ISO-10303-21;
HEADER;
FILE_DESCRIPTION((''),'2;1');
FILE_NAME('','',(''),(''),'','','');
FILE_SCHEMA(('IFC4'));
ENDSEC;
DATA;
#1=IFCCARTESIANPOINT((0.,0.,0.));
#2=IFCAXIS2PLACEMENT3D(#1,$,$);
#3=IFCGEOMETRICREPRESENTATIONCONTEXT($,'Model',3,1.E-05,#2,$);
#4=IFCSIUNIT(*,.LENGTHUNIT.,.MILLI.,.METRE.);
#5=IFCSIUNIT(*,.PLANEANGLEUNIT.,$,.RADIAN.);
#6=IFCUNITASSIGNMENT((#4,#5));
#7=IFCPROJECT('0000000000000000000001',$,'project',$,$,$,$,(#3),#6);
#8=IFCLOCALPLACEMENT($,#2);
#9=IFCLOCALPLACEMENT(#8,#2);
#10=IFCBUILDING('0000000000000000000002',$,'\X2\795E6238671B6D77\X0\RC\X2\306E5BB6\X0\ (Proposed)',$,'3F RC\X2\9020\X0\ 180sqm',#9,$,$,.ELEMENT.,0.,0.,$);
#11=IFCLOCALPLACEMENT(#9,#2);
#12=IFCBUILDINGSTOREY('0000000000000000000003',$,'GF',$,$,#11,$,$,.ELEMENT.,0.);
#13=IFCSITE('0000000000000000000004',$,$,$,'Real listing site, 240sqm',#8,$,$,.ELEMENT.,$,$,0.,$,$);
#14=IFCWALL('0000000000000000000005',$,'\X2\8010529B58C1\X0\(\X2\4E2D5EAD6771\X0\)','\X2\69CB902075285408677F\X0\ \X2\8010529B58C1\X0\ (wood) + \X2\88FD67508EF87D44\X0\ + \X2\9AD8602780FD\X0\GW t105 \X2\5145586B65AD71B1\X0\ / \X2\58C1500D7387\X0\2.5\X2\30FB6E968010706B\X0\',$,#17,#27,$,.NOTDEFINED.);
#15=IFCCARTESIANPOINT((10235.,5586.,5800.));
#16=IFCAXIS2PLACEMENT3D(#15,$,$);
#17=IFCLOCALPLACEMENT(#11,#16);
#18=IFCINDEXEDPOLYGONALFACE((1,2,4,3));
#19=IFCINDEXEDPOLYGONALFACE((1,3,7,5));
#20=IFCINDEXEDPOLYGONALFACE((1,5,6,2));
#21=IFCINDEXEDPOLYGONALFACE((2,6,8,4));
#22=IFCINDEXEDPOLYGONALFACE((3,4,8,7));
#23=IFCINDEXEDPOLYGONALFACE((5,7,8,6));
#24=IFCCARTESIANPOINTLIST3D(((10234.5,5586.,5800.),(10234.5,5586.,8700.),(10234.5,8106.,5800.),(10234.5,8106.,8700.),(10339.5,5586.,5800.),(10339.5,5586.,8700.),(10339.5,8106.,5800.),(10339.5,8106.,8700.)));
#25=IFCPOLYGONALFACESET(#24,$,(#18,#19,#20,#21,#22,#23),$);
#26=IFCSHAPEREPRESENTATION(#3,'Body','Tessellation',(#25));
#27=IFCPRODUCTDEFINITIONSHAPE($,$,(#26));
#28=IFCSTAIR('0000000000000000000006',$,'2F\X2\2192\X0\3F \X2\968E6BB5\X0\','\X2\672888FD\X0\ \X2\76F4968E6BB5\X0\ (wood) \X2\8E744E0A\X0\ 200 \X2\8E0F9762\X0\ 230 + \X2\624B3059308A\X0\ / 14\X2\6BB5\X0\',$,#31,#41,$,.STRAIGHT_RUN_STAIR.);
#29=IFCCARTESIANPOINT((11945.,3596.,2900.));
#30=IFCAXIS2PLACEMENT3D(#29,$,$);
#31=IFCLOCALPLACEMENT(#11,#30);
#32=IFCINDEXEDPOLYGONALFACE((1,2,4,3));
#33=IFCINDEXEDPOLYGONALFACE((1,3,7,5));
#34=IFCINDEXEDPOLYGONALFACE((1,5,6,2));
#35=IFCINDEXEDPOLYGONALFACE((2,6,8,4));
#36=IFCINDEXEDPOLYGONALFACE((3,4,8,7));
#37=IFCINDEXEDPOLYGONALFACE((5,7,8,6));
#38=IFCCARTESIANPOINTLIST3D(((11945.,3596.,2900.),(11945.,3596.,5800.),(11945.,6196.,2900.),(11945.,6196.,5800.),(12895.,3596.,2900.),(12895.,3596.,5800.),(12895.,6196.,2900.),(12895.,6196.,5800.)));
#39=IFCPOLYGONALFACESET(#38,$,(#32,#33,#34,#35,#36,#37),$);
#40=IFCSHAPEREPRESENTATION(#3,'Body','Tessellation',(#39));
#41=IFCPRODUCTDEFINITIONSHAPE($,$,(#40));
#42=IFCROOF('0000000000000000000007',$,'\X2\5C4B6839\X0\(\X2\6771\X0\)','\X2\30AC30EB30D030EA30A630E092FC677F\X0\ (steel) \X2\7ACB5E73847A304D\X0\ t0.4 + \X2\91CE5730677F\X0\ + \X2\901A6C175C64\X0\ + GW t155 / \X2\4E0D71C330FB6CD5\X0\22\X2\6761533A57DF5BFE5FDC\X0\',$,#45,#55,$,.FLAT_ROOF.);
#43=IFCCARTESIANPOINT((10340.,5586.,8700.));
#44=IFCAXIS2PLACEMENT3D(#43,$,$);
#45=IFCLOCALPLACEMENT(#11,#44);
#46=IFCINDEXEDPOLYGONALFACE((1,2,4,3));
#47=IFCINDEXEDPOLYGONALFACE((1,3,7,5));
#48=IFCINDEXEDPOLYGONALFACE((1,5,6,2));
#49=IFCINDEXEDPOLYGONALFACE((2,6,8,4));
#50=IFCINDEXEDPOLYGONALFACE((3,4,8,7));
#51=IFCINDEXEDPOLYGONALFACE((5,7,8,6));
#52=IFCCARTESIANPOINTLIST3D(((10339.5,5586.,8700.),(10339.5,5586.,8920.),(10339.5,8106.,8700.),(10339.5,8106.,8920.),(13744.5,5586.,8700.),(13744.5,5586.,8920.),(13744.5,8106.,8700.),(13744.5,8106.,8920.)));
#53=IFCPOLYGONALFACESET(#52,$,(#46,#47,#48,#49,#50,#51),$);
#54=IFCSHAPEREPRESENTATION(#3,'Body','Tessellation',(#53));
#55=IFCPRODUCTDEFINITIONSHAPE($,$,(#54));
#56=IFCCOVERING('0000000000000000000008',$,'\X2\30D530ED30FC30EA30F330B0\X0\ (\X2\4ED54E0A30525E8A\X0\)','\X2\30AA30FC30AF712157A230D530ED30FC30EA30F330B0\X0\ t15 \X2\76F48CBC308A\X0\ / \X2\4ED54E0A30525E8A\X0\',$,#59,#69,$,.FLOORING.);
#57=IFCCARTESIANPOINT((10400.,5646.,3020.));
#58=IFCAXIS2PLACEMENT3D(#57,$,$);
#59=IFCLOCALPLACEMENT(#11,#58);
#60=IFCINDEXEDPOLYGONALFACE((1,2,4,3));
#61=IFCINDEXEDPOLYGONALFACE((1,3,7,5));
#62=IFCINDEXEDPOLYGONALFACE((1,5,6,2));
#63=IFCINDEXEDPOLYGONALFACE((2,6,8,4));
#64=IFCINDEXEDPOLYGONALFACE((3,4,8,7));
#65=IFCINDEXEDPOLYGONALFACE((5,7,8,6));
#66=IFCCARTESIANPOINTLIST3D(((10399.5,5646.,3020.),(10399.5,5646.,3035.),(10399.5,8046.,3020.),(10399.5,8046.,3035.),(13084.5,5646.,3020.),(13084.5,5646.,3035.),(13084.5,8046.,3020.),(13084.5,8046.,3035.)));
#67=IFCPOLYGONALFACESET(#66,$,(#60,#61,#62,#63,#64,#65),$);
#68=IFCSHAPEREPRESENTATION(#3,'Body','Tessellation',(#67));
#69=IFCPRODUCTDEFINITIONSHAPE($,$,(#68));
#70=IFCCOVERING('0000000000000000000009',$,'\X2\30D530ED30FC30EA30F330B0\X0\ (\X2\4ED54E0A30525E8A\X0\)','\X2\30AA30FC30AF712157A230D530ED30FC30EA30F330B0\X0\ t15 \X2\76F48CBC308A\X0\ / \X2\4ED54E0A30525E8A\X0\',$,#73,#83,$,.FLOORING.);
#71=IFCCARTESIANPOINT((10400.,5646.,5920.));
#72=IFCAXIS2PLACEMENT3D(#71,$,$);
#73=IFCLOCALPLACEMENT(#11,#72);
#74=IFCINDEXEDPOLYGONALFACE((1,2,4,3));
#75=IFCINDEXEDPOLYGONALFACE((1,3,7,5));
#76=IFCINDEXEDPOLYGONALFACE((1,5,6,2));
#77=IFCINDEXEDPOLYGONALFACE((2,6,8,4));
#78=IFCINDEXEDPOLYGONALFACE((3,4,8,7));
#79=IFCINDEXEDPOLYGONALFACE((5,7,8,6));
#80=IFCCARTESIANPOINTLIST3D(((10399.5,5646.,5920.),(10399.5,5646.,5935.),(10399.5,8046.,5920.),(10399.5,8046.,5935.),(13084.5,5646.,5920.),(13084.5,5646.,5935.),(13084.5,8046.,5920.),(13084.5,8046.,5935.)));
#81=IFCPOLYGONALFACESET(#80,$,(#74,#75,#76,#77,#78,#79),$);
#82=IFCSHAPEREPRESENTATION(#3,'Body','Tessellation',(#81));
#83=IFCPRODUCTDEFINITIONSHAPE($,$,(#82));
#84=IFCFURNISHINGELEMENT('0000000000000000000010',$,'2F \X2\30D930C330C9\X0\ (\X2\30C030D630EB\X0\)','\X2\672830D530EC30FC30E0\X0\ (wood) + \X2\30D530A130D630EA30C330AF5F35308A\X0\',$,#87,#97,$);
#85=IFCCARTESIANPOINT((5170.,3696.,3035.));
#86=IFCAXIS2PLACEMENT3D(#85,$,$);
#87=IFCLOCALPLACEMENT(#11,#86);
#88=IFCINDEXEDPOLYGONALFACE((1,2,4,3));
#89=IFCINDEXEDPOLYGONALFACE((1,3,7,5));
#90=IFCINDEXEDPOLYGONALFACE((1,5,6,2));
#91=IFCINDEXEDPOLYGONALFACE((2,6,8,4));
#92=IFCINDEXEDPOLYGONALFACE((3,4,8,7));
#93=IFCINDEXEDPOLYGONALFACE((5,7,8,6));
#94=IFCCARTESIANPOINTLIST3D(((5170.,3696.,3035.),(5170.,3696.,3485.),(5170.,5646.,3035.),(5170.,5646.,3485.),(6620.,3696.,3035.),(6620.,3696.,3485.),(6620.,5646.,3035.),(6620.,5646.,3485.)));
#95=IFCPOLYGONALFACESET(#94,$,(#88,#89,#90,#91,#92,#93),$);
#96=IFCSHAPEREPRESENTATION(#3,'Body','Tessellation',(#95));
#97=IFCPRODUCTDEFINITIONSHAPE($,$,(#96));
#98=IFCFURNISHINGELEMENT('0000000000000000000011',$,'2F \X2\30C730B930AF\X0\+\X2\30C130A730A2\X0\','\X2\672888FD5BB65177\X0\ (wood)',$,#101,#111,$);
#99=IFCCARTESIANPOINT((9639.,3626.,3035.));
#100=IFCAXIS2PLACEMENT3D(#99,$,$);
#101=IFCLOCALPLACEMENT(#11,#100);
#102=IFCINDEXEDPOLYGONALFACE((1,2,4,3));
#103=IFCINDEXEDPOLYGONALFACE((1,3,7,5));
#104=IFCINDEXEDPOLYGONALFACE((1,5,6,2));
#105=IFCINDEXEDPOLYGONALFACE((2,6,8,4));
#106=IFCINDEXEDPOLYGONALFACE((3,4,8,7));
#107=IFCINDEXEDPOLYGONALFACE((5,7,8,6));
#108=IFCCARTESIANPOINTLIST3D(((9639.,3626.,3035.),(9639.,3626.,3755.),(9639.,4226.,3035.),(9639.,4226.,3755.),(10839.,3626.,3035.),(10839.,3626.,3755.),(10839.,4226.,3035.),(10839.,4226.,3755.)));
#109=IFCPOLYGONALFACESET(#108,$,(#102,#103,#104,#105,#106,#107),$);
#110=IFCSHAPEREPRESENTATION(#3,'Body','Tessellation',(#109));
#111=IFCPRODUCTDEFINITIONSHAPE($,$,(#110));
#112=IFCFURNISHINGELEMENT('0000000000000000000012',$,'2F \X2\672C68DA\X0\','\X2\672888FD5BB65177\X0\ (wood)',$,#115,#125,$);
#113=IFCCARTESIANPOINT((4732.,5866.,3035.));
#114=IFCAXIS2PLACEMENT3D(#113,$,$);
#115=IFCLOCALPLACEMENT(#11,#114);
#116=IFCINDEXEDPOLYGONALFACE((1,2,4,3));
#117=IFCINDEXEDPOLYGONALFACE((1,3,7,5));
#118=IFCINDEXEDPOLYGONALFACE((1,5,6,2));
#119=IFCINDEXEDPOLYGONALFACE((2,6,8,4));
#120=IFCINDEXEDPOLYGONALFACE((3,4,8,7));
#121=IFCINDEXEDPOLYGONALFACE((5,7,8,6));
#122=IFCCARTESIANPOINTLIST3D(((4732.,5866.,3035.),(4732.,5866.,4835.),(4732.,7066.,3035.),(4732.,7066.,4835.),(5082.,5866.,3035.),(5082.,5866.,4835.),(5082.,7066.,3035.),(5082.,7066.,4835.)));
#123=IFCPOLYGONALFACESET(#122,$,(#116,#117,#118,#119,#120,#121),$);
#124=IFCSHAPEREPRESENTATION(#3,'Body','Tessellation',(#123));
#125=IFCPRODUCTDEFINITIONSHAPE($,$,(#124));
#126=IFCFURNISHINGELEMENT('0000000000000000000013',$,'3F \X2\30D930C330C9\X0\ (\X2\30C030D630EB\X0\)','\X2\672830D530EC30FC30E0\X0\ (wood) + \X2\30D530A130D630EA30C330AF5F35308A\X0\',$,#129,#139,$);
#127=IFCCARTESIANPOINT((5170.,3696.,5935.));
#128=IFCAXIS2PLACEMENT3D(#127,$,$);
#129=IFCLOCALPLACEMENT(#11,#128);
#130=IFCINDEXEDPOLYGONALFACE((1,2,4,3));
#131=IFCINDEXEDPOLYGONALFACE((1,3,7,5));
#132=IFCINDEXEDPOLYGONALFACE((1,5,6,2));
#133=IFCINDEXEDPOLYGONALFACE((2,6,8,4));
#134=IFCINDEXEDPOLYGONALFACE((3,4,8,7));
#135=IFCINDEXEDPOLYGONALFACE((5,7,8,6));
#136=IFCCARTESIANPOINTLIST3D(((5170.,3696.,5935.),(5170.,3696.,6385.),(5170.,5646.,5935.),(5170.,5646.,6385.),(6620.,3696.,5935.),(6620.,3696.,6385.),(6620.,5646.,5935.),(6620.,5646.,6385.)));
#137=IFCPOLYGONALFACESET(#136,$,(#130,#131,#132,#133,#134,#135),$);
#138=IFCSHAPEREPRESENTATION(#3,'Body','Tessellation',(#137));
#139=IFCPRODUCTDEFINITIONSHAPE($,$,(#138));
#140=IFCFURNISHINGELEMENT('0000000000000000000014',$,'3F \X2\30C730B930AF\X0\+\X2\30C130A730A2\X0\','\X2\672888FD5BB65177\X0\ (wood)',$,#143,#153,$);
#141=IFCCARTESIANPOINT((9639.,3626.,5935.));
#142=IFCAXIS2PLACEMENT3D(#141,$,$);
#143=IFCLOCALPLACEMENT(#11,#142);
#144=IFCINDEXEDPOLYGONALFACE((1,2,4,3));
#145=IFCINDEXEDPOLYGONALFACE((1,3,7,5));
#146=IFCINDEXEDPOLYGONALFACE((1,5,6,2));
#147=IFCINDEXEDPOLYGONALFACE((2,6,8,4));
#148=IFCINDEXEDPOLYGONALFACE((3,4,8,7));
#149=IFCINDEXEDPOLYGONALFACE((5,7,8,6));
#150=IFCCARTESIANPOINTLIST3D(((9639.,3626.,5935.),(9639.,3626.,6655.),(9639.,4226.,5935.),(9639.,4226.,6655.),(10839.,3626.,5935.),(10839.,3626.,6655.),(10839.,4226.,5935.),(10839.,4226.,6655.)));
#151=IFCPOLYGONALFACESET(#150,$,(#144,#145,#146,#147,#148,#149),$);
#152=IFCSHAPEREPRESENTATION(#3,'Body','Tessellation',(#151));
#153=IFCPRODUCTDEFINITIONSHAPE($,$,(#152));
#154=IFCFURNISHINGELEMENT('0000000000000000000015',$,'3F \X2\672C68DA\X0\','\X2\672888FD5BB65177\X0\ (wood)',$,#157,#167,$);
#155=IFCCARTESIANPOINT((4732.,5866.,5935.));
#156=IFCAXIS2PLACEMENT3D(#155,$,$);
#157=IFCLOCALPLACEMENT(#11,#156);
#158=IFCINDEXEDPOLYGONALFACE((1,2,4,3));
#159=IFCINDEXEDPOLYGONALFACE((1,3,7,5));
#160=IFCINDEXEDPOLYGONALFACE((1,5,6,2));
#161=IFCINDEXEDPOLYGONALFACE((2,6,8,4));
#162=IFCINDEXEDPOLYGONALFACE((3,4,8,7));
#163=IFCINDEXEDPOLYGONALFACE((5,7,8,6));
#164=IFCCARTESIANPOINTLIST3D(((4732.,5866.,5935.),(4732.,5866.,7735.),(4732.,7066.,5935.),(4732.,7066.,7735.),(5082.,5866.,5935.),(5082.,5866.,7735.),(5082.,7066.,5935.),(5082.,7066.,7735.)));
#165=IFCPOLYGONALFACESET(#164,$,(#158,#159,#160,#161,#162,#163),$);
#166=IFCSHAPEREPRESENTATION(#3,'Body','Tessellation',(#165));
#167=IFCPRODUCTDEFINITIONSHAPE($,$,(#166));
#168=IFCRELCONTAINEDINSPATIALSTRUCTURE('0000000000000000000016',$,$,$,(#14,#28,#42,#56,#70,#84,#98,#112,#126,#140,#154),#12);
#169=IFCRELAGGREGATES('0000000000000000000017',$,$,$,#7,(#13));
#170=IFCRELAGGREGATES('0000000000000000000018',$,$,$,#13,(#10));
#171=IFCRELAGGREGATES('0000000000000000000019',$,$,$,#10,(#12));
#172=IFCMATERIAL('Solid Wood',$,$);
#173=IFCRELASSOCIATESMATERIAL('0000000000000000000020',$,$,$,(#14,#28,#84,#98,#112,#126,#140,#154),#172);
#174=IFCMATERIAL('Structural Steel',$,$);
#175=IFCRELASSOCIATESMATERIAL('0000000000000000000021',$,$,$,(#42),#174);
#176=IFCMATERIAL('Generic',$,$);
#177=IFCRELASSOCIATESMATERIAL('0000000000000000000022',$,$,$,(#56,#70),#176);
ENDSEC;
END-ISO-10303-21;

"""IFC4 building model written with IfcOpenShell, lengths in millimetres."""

from ifc_helpers import new_model, si_unit, frame, frame_2d, origin, place, context, project, spatial, rectangle, extrude, material, element, save


model = new_model("IFC4")

# Units and contexts
model_context = context("Model", 3, precision=1e-05, world=origin())
ifc_project = project(units=[si_unit("LENGTHUNIT", "METRE", prefix="MILLI"), si_unit("PLANEANGLEUNIT", "RADIAN")], contexts=[model_context])

# Site, building, storey
site_placement = place(None, origin())
site = spatial("IfcSite", under=ifc_project, at=site_placement, ObjectType="Real listing site, 240sqm", CompositionType="ELEMENT", RefElevation=0.0)
building_placement = place(site_placement, origin())
building = spatial("IfcBuilding", under=site, at=building_placement, Name="神戸望海RCの家 (Proposed)", ObjectType="3F RC造 180sqm", CompositionType="ELEMENT", ElevationOfRefHeight=0.0, ElevationOfTerrain=0.0)
storey_placement = place(building_placement, origin())
storey = spatial("IfcBuildingStorey", under=building, at=storey_placement, Name="GF", CompositionType="ELEMENT", Elevation=0.0)

# Shared definitions
ifc_material_1 = material(Name="Solid Wood")

# Wall
wall_1_placement = place(storey_placement, frame((10235.0, 5586.0, 5800.0)))
element("IfcWall", 1, at=wall_1_placement, inside=storey, material=ifc_material_1, Name="耐力壁(中庭東)", Description="構造用合板 耐力壁 (wood) + 製材軸組 + 高性能GW t105 充填断熱 / 壁倍率2.5・準耐火", PredefinedType="NOTDEFINED", context=model_context, shape_type="SweptSolid", body=[
    extrude(rectangle(XDim=105.0, YDim=2520.0, at=frame_2d((52.0, 1260.0))), frame((10235.0, 5586.0, 5800.0)), (0.0, 0.0, 1.0), 2900.0),
])

# Stair
stair_placement = place(storey_placement, frame((11945.0, 3596.0, 2900.0)))
element("IfcStair", 2, at=stair_placement, inside=storey, material=ifc_material_1, Name="2F→3F 階段", Description="木製 直階段 (wood) 蹴上 200 踏面 230 + 手すり / 14段", PredefinedType="STRAIGHT_RUN_STAIR", context=model_context, shape_type="SweptSolid", body=[
    extrude(rectangle(XDim=950.0, YDim=2600.0, at=frame_2d((475.0, 1300.0))), frame((11945.0, 3596.0, 2900.0)), (0.0, 0.0, 1.0), 2900.0),
])

# Roof
ifc_material_2 = material(Name="Structural Steel")
for number, where, name in (
    (3, (10340.0, 5586.0, 8700.0), "屋根(東)"),
):
    element("IfcRoof", number, at=place(storey_placement, frame(where)), inside=storey, material=ifc_material_2, Name=name, Description="ガルバリウム鋼板 (steel) 立平葺き t0.4 + 野地板 + 通気層 + GW t155 / 不燃・法22条区域対応", PredefinedType="FLAT_ROOF", context=model_context, shape_type="SweptSolid", body=[
        extrude(rectangle(XDim=3405.0, YDim=2520.0, at=frame_2d((1702.0, 1260.0))), frame((10340.0, 5586.0, 8700.0)), (0.0, 0.0, 1.0), 220.0),
    ])

# Coverings
ifc_material_3 = material(Name="Generic")
covering_1_placement = place(storey_placement, frame((10400.0, 5646.0, 3020.0)))
element("IfcCovering", 4, at=covering_1_placement, inside=storey, material=ifc_material_3, Name="フローリング (仕上げ床)", Description="オーク無垢フローリング t15 直貼り / 仕上げ床", PredefinedType="FLOORING", context=model_context, shape_type="SweptSolid", body=[
    extrude(rectangle(XDim=2685.0, YDim=2400.0, at=frame_2d((1342.0, 1200.0))), frame((10400.0, 5646.0, 3020.0)), (0.0, 0.0, 1.0), 15.0),
])
covering_2_placement = place(storey_placement, frame((10400.0, 5646.0, 5920.0)))
element("IfcCovering", 5, at=covering_2_placement, inside=storey, material=ifc_material_3, Name="フローリング (仕上げ床)", Description="オーク無垢フローリング t15 直貼り / 仕上げ床", PredefinedType="FLOORING", context=model_context, shape_type="SweptSolid", body=[
    extrude(rectangle(XDim=2685.0, YDim=2400.0, at=frame_2d((1342.0, 1200.0))), frame((10400.0, 5646.0, 5920.0)), (0.0, 0.0, 1.0), 15.0),
])

# Furnishing elements
furnishing_1_placement = place(storey_placement, frame((5170.0, 3696.0, 3035.0)))
element("IfcFurnishingElement", 6, at=furnishing_1_placement, inside=storey, material=ifc_material_1, Name="2F ベッド (ダブル)", Description="木フレーム (wood) + ファブリック張り", context=model_context, shape_type="SweptSolid", body=[
    extrude(rectangle(XDim=1450.0, YDim=1950.0, at=frame_2d((725.0, 975.0))), frame((5170.0, 3696.0, 3035.0)), (0.0, 0.0, 1.0), 450.0),
])
furnishing_2_placement = place(storey_placement, frame((9639.0, 3626.0, 3035.0)))
element("IfcFurnishingElement", 7, at=furnishing_2_placement, inside=storey, material=ifc_material_1, Name="2F デスク+チェア", Description="木製家具 (wood)", context=model_context, shape_type="SweptSolid", body=[
    extrude(rectangle(XDim=1200.0, YDim=600.0, at=frame_2d((600.0, 300.0))), frame((9639.0, 3626.0, 3035.0)), (0.0, 0.0, 1.0), 720.0),
])
furnishing_3_placement = place(storey_placement, frame((4732.0, 5866.0, 3035.0)))
element("IfcFurnishingElement", 8, at=furnishing_3_placement, inside=storey, material=ifc_material_1, Name="2F 本棚", Description="木製家具 (wood)", context=model_context, shape_type="SweptSolid", body=[
    extrude(rectangle(XDim=350.0, YDim=1200.0, at=frame_2d((175.0, 600.0))), frame((4732.0, 5866.0, 3035.0)), (0.0, 0.0, 1.0), 1800.0),
])
furnishing_4_placement = place(storey_placement, frame((5170.0, 3696.0, 5935.0)))
element("IfcFurnishingElement", 9, at=furnishing_4_placement, inside=storey, material=ifc_material_1, Name="3F ベッド (ダブル)", Description="木フレーム (wood) + ファブリック張り", context=model_context, shape_type="SweptSolid", body=[
    extrude(rectangle(XDim=1450.0, YDim=1950.0, at=frame_2d((725.0, 975.0))), frame((5170.0, 3696.0, 5935.0)), (0.0, 0.0, 1.0), 450.0),
])
furnishing_5_placement = place(storey_placement, frame((9639.0, 3626.0, 5935.0)))
element("IfcFurnishingElement", 10, at=furnishing_5_placement, inside=storey, material=ifc_material_1, Name="3F デスク+チェア", Description="木製家具 (wood)", context=model_context, shape_type="SweptSolid", body=[
    extrude(rectangle(XDim=1200.0, YDim=600.0, at=frame_2d((600.0, 300.0))), frame((9639.0, 3626.0, 5935.0)), (0.0, 0.0, 1.0), 720.0),
])
furnishing_6_placement = place(storey_placement, frame((4732.0, 5866.0, 5935.0)))
element("IfcFurnishingElement", 11, at=furnishing_6_placement, inside=storey, material=ifc_material_1, Name="3F 本棚", Description="木製家具 (wood)", context=model_context, shape_type="SweptSolid", body=[
    extrude(rectangle(XDim=350.0, YDim=1200.0, at=frame_2d((175.0, 600.0))), frame((4732.0, 5866.0, 5935.0)), (0.0, 0.0, 1.0), 1800.0),
])

save(model, "model.ifc")
